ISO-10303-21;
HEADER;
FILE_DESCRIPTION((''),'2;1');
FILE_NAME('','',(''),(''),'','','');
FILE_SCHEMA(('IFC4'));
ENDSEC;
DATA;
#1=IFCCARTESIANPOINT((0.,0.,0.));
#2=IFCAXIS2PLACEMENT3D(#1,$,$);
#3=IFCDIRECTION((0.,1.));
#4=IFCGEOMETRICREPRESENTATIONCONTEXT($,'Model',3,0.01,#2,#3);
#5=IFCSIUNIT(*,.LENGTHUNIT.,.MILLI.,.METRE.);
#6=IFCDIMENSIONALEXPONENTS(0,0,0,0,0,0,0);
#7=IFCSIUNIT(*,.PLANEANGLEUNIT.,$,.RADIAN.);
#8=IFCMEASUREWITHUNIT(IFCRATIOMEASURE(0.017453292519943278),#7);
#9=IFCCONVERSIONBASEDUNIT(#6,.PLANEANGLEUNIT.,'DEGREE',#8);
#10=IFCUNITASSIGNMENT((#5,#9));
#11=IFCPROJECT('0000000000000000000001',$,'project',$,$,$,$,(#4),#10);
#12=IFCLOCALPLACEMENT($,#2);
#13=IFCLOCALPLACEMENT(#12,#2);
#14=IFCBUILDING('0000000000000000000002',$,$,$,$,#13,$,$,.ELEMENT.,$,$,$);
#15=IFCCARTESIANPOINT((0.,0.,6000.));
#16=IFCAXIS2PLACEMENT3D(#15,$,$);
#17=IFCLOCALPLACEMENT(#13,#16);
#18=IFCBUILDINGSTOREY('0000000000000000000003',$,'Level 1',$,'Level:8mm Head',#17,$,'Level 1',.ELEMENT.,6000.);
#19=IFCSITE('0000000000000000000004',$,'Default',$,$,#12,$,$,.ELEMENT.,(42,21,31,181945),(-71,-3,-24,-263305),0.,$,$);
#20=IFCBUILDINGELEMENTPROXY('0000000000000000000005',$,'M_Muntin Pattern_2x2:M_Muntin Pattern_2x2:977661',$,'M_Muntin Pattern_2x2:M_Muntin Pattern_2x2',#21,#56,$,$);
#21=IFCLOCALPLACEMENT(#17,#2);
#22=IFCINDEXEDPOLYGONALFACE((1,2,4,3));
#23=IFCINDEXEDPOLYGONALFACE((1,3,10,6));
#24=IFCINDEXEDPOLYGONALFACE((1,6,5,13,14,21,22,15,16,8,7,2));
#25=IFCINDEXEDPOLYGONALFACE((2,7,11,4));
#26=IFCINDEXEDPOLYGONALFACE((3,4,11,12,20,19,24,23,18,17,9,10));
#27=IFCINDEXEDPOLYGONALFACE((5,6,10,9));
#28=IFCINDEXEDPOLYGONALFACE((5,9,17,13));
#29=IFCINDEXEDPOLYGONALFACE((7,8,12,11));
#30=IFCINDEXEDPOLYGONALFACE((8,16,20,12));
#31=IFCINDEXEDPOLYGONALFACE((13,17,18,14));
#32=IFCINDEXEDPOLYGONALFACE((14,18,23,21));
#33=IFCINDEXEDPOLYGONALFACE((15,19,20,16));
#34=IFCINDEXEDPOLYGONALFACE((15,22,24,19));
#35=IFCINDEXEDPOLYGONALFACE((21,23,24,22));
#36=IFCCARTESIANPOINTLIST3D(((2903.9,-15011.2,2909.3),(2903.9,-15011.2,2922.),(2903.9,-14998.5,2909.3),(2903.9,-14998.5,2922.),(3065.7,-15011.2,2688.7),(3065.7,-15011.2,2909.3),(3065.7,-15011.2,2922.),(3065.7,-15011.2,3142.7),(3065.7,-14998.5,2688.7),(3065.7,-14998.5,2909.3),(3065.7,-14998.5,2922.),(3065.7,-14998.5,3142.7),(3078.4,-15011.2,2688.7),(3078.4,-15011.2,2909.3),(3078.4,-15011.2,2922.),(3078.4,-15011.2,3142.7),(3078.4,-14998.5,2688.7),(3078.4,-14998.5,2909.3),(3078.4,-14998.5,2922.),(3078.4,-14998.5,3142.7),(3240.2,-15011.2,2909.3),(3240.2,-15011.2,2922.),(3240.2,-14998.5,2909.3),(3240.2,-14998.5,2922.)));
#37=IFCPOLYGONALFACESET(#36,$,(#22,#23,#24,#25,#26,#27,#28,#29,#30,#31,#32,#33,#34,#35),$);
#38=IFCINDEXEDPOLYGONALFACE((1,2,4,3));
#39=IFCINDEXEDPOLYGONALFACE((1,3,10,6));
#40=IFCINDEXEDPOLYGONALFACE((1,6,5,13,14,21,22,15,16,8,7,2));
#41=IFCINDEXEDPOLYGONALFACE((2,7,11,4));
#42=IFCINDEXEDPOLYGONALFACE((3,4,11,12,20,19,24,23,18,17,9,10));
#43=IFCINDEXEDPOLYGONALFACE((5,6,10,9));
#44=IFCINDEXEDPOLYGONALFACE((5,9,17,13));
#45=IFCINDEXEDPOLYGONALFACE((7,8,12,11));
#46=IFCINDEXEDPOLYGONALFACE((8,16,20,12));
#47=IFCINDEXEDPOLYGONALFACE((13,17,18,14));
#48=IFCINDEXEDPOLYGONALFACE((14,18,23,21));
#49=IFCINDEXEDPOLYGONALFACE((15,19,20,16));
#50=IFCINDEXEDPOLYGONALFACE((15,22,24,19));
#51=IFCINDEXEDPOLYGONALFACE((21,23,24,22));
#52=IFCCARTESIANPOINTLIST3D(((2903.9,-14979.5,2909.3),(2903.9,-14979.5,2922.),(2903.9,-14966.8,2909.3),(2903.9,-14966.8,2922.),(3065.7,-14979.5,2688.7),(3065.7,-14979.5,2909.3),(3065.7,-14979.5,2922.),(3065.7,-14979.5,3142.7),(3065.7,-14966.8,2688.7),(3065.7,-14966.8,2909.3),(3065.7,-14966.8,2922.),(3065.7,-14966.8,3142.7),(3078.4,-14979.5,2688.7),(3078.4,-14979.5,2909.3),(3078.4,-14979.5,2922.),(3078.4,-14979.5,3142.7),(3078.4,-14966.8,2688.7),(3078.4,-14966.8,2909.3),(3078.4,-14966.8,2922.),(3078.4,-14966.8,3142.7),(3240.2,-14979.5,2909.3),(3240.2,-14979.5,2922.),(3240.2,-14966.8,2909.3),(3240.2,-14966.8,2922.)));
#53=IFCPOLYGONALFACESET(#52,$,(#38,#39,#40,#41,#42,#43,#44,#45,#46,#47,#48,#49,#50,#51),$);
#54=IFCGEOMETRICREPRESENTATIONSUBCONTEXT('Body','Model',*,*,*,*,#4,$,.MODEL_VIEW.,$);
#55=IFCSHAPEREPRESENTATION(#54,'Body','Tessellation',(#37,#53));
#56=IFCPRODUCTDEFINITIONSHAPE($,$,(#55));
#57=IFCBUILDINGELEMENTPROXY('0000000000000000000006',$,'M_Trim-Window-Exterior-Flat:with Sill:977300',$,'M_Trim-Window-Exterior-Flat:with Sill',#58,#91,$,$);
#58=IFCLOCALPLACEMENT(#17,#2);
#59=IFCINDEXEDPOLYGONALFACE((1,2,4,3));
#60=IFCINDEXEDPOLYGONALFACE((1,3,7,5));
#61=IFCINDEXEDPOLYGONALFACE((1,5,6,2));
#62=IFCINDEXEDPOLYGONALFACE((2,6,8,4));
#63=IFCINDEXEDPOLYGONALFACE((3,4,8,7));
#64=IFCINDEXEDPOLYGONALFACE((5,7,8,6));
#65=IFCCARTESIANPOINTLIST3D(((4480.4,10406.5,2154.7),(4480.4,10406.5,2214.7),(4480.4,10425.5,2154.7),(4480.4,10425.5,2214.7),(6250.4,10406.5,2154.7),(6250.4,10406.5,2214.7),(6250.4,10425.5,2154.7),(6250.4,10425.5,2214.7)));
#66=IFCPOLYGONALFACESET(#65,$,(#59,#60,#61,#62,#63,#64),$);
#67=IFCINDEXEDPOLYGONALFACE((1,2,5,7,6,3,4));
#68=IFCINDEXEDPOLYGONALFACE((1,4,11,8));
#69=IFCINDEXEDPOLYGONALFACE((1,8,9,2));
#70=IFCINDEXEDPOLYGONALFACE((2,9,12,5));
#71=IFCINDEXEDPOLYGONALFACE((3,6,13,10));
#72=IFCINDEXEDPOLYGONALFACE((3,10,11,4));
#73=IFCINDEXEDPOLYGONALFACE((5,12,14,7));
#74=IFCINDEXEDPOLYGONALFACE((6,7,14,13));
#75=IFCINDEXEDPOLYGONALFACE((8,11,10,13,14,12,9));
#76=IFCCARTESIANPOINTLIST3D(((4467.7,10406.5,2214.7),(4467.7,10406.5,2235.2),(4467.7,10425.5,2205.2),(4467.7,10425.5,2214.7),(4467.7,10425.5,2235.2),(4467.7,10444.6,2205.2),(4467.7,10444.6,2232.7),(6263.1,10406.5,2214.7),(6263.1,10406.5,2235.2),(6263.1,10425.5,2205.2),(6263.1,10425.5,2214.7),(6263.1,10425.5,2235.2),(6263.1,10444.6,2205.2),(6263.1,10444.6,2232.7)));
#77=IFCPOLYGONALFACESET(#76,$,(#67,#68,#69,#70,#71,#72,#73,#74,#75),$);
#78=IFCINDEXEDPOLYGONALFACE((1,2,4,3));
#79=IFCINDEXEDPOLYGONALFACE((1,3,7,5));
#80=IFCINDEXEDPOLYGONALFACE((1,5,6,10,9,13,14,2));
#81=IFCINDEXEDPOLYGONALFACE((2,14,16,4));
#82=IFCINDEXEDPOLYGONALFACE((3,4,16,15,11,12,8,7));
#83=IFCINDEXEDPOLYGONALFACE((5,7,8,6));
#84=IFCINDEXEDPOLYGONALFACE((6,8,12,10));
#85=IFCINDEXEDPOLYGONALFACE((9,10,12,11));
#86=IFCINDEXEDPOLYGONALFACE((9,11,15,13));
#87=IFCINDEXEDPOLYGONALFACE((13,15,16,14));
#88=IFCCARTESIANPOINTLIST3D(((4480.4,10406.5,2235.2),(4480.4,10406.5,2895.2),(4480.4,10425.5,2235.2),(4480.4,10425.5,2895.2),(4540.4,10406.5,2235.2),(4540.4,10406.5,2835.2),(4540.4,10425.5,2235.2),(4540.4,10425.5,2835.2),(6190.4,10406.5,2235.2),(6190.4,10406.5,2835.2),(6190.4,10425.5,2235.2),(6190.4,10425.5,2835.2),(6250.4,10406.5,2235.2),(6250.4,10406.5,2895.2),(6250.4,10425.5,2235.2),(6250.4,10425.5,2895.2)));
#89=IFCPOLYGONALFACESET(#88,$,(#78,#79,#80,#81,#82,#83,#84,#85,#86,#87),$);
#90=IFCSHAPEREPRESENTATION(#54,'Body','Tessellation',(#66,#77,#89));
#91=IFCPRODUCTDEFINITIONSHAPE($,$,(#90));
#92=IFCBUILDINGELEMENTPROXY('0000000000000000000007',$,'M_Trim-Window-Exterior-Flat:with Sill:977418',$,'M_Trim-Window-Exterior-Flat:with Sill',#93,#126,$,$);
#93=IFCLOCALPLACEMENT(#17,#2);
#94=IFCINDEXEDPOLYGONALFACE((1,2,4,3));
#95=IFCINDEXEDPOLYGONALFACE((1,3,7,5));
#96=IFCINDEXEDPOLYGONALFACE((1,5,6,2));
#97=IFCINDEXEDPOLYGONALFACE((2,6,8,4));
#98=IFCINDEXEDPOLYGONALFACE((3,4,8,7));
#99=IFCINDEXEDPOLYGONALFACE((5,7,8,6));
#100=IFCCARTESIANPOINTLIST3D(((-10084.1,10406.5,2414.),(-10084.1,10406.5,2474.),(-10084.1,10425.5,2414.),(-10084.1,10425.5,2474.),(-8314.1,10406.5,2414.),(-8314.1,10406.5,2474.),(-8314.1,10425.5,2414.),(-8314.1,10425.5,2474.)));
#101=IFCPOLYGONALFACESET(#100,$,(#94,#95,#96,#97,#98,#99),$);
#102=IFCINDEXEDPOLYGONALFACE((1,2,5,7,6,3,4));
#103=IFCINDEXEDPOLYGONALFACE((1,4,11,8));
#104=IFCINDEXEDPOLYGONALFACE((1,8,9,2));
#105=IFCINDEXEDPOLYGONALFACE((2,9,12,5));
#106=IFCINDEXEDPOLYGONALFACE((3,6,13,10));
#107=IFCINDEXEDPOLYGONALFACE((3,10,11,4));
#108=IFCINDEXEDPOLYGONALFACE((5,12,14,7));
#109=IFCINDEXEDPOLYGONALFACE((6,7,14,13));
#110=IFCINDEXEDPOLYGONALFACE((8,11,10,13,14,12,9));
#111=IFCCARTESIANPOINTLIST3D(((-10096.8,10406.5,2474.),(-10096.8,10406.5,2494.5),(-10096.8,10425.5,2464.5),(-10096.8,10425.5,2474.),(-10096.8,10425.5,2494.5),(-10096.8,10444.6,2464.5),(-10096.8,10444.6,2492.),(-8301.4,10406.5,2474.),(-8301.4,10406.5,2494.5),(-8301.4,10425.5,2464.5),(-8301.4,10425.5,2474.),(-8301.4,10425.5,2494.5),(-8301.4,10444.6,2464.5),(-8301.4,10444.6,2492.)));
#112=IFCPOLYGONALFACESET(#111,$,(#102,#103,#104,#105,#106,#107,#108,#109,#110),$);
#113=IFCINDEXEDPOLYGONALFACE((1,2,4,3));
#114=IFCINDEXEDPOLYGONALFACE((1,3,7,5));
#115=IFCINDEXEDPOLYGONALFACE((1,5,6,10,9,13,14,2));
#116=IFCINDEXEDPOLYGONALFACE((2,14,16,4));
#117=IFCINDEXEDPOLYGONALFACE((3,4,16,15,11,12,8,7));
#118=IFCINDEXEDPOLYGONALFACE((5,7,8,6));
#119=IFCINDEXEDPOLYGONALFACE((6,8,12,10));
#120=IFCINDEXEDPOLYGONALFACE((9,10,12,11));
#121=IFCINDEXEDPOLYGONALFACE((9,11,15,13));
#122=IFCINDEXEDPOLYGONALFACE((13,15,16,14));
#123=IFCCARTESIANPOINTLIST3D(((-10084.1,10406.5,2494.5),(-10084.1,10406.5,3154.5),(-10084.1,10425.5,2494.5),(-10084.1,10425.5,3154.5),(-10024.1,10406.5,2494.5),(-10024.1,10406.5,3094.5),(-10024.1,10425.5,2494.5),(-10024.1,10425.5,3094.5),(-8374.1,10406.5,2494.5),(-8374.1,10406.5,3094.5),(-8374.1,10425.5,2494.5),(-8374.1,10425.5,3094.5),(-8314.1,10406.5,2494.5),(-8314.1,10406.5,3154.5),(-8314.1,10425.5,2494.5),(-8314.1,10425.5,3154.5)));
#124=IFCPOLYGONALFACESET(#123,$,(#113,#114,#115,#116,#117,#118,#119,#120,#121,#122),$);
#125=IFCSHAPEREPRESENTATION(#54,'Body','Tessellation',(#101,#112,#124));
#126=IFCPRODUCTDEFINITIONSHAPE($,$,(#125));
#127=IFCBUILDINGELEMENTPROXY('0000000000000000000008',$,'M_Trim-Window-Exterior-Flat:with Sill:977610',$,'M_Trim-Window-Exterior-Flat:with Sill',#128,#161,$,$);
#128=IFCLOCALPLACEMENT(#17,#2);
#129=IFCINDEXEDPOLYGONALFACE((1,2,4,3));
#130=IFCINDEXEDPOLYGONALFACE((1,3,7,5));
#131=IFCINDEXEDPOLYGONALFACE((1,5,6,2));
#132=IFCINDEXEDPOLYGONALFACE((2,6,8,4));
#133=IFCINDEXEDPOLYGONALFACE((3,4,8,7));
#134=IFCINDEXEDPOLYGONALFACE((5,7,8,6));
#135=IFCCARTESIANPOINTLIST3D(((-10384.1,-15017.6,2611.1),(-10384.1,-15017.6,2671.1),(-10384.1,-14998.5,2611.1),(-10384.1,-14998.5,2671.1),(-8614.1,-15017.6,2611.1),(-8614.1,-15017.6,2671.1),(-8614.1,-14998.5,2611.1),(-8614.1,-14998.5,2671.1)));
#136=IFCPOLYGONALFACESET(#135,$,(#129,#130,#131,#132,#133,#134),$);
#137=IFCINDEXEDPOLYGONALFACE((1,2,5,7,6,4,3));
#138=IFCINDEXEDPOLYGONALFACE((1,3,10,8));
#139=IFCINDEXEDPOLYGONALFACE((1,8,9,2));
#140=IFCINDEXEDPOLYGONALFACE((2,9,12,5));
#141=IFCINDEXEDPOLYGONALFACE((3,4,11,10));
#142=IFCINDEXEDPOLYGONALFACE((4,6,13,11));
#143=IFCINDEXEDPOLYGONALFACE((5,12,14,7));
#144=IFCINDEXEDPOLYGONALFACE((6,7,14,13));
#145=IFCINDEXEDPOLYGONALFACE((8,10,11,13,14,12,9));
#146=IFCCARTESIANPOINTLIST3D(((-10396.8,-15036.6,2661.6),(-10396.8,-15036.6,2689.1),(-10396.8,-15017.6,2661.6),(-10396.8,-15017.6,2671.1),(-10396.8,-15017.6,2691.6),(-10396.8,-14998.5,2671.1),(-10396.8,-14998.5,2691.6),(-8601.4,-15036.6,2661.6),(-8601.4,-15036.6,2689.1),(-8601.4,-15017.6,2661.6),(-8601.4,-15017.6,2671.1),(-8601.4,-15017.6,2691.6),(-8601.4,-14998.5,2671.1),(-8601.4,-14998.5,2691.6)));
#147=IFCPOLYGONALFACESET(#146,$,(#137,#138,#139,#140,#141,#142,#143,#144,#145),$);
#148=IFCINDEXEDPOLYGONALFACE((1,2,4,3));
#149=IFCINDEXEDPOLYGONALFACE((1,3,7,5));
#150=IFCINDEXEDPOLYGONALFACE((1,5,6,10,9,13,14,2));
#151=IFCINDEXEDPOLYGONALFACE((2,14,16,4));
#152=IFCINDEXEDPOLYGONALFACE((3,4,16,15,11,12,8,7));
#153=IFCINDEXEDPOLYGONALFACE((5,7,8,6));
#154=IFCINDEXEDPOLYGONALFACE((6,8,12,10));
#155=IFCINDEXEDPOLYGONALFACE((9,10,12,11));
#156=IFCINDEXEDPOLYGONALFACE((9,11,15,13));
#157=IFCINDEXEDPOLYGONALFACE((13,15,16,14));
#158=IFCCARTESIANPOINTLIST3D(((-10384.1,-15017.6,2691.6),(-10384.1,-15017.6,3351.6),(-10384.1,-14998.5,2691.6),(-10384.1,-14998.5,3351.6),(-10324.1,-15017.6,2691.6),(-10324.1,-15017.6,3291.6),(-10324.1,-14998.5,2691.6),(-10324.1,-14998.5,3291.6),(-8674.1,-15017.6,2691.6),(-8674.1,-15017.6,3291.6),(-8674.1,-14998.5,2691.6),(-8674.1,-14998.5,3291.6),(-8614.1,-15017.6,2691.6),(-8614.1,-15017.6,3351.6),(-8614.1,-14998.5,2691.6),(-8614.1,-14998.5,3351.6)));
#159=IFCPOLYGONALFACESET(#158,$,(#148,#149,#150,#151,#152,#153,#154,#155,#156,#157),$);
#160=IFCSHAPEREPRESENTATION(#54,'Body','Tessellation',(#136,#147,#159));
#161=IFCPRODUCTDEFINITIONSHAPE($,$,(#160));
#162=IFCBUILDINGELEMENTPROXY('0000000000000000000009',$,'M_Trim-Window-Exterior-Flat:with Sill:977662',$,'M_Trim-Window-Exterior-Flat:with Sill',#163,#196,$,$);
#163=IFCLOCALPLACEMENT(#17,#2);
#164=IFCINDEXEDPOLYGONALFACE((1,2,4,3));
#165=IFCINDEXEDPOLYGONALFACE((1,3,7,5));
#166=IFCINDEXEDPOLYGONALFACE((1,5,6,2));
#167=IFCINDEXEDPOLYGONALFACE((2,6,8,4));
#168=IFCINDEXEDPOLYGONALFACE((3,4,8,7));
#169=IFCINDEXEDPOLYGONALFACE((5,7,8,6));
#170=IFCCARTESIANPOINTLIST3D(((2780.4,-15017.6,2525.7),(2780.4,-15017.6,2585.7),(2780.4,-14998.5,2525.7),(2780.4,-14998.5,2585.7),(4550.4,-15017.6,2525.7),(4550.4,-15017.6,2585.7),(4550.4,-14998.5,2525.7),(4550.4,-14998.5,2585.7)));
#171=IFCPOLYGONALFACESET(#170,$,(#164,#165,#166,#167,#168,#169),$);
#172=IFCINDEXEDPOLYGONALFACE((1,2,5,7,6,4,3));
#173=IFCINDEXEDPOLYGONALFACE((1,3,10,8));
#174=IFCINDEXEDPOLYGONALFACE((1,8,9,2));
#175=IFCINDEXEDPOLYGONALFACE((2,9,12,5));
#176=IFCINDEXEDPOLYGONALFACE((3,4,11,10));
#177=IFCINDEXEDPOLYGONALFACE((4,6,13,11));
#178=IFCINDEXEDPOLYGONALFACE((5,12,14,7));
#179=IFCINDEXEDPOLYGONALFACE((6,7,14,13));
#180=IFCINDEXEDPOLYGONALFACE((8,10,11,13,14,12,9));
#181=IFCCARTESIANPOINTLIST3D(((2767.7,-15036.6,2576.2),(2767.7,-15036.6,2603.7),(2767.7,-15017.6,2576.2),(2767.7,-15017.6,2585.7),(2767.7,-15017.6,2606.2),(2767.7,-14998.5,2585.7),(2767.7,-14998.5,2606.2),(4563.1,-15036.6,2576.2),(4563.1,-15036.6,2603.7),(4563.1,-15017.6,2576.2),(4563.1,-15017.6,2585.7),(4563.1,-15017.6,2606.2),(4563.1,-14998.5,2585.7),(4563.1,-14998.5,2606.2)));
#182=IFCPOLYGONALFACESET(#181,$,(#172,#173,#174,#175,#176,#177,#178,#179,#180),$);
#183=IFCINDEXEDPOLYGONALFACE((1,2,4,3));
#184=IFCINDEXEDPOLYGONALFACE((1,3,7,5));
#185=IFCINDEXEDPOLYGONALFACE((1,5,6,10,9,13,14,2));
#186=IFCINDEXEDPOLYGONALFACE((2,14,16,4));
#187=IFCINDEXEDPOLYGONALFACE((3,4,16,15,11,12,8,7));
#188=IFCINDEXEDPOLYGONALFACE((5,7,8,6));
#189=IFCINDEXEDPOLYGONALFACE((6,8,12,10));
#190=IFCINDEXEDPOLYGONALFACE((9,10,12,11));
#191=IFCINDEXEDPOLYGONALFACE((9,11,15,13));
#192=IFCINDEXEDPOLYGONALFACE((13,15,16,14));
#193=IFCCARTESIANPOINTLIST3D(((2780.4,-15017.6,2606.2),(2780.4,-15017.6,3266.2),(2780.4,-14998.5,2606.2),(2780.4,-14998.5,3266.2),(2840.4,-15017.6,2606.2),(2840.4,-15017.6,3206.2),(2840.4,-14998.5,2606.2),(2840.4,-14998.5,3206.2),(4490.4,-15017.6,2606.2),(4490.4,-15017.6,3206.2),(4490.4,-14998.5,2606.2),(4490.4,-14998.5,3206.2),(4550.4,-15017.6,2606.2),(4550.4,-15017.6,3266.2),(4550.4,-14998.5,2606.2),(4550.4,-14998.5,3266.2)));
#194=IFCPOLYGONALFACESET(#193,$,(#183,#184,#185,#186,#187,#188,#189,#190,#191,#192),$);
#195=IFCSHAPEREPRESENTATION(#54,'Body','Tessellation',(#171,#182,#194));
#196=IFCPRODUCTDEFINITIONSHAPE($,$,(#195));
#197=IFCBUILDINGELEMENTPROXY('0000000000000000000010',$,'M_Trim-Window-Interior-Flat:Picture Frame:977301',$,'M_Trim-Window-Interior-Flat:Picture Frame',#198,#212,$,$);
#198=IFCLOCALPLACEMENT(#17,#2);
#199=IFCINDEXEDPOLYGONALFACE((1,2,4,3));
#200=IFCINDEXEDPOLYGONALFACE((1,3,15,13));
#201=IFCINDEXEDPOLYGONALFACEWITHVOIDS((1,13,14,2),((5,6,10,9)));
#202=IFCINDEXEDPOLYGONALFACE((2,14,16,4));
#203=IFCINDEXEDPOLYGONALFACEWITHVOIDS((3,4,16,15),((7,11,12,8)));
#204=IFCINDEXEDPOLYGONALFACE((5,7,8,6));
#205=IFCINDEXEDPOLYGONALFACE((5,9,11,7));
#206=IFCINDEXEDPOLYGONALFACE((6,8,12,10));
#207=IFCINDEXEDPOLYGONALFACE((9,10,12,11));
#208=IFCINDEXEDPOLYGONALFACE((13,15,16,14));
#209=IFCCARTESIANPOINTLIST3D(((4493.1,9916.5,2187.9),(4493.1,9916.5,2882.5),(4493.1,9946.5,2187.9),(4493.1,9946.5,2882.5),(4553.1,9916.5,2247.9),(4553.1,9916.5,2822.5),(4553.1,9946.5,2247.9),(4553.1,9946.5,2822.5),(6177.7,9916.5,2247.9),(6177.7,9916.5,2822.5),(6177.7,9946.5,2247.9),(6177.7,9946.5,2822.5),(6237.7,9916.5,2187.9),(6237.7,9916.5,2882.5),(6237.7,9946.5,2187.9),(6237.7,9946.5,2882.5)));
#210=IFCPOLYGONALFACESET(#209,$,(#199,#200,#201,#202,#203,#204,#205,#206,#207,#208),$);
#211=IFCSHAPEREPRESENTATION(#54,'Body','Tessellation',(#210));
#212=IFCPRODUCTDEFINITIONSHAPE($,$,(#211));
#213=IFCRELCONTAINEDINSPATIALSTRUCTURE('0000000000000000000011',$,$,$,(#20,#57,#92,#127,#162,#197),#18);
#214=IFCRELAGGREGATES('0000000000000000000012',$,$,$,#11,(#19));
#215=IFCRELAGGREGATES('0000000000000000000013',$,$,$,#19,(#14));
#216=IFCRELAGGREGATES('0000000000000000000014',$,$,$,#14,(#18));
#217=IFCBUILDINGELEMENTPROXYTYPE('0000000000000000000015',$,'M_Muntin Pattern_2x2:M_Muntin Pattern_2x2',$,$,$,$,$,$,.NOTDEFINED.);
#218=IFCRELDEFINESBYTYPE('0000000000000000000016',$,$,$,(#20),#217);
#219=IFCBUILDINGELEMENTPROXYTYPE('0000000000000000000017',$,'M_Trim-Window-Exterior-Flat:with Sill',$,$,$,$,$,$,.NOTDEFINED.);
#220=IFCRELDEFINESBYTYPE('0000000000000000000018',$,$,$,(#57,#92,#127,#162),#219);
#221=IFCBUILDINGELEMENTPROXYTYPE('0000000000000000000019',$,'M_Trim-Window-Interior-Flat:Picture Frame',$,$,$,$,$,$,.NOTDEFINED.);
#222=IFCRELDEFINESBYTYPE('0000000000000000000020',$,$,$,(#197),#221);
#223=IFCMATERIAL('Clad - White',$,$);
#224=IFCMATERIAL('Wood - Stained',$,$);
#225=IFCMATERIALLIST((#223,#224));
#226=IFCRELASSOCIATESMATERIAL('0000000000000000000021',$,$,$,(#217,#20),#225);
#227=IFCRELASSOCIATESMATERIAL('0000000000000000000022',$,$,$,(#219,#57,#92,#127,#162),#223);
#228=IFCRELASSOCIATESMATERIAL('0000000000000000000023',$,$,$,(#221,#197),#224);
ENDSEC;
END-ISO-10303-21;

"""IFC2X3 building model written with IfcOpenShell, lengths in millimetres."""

from ifc_helpers import new_model, entity, si_unit, converted_unit, direction, frame, frame_2d, origin, place, context, subcontext, project, spatial, polyline, rectangle, outline, extrude, source, transform, mapped, material, material_list, type_object, type_shapes, element, save


model = new_model("IFC2X3")

# Units and contexts
model_context = context("Model", 3, precision=0.01, world=origin(), true_north=direction((0.0, 1.0)))
body_context = subcontext(model_context, "Body", "Model", "MODEL_VIEW")
ifc_project = project(units=[si_unit("LENGTHUNIT", "METRE", prefix="MILLI"), converted_unit("PLANEANGLEUNIT", "DEGREE", entity("IfcRatioMeasure", 0.017453292519943278), si_unit("PLANEANGLEUNIT", "RADIAN"), dimensions=[0, 0, 0, 0, 0, 0, 0])], contexts=[model_context])

# Site, building, storey
site_placement = place(None, origin())
site = spatial("IfcSite", under=ifc_project, at=site_placement, Name="Default", CompositionType="ELEMENT", RefLatitude=(42, 21, 31, 181945), RefLongitude=(-71, -3, -24, -263305), RefElevation=0.0)
building_placement = place(site_placement, origin())
building = spatial("IfcBuilding", under=site, at=building_placement, CompositionType="ELEMENT")
storey_placement = place(building_placement, frame((0.0, 0.0, 6000.0)))
storey = spatial("IfcBuildingStorey", under=building, at=storey_placement, Name="Level 1", ObjectType="Level:8mm Head", LongName="Level 1", CompositionType="ELEMENT", Elevation=6000.0)

# Building element proxies
ifc_material_1 = material(Name="Clad - White")
ifc_material_2 = material(Name="Wood - Stained")
ifc_material_list_1 = material_list([ifc_material_1, ifc_material_2])
building_element_proxy_type_1 = type_object("IfcBuildingElementProxyType", Name="M_Muntin Pattern_2x2:M_Muntin Pattern_2x2", PredefinedType="NOTDEFINED", material=ifc_material_list_1)
shared_shape_1 = source(origin(), body_context, "Body", "SweptSolid", [
    extrude(outline(polyline([(6.4, -6.4), (227.0, -6.4), (227.0, 6.3), (6.4, 6.3), (6.4, 168.2), (-6.3, 168.2), (-6.3, 6.3), (-227.0, 6.3), (-227.0, -6.4), (-6.3, -6.4), (-6.3, -168.1), (6.4, -168.1), (6.4, -6.4)])), frame((0.0, 9.5, 227.0), z_axis=(0.0, 1.0, 0.0), x_axis=(0.0, 0.0, 1.0)), (0.0, 0.0, 1.0), 12.7),
    extrude(outline(polyline([(6.4, -6.4), (227.0, -6.4), (227.0, 6.3), (6.4, 6.3), (6.4, 168.2), (-6.3, 168.2), (-6.3, 6.3), (-227.0, 6.3), (-227.0, -6.4), (-6.3, -6.4), (-6.3, -168.1), (6.4, -168.1), (6.4, -6.4)])), frame((0.0, -22.2, 227.0), z_axis=(0.0, 1.0, 0.0), x_axis=(0.0, 0.0, 1.0)), (0.0, 0.0, 1.0), 12.7),
])
type_shapes(building_element_proxy_type_1, [shared_shape_1])
for number, where, z_axis, x_axis, name in (
    (1, (3072.1, -14989.0, 2688.7), (0.0, 0.0, 1.0), (-1.0, 0.0, 0.0), "M_Muntin Pattern_2x2:M_Muntin Pattern_2x2:977661"),
):
    element("IfcBuildingElementProxy", number, at=place(storey_placement, frame(where, z_axis=z_axis, x_axis=x_axis)), inside=storey, type_object=building_element_proxy_type_1, material=ifc_material_list_1, Name=name, ObjectType="M_Muntin Pattern_2x2:M_Muntin Pattern_2x2", context=body_context, shape_type="MappedRepresentation", body=[
        mapped(shared_shape_1, transform((0.0, 0.0, 0.0), scale=1.0)),
    ])
building_element_proxy_type_2 = type_object("IfcBuildingElementProxyType", Name="M_Trim-Window-Exterior-Flat:with Sill", PredefinedType="NOTDEFINED", material=ifc_material_1)
shared_shape_2 = source(origin(), body_context, "Body", "SweptSolid", [
    extrude(rectangle(XDim=1770.0, YDim=60.0, at=frame_2d((0.0, 0.0), x_axis=(1.0, 0.0))), frame((0.0, -650.4, 0.0), z_axis=(0.0, 0.0, 1.0), x_axis=(-1.0, 0.0, 0.0)), (0.0, 0.0, 1.0), 19.0),
    extrude(outline(polyline([(-19.0, -15.2), (0.0, -15.2), (0.0, -5.7), (19.0, -5.7), (19.0, 14.8), (0.0, 14.8), (-19.0, 12.3), (-19.0, -15.2)])), frame((-897.7, -614.8, 19.0), z_axis=(1.0, 0.0, 0.0), x_axis=(0.0, 0.0, -1.0)), (0.0, 0.0, 1.0), 1795.4),
    extrude(outline(polyline([(-345.0, -885.0), (315.0, -885.0), (315.0, -825.0), (-285.0, -825.0), (-285.0, 825.0), (315.0, 825.0), (315.0, 885.0), (-345.0, 885.0), (-345.0, -885.0)])), frame((0.0, -285.0, 0.0), z_axis=(0.0, 0.0, 1.0), x_axis=(0.0, -1.0, 0.0)), (0.0, 0.0, 1.0), 19.0),
])
type_shapes(building_element_proxy_type_2, [shared_shape_2])
for number, where, z_axis, x_axis, name in (
    (2, (5365.4, 10406.5, 2835.2), (0.0, 1.0, 0.0), (-1.0, 0.0, 0.0), "M_Trim-Window-Exterior-Flat:with Sill:977300"),
    (3, (-9199.1, 10406.5, 3094.5), (0.0, 1.0, 0.0), (-1.0, 0.0, 0.0), "M_Trim-Window-Exterior-Flat:with Sill:977418"),
    (4, (-9499.1, -14998.5, 3291.6), (0.0, -1.0, 0.0), (1.0, 0.0, 0.0), "M_Trim-Window-Exterior-Flat:with Sill:977610"),
    (5, (3665.4, -14998.5, 3206.2), (0.0, -1.0, 0.0), (1.0, 0.0, 0.0), "M_Trim-Window-Exterior-Flat:with Sill:977662"),
):
    element("IfcBuildingElementProxy", number, at=place(storey_placement, frame(where, z_axis=z_axis, x_axis=x_axis)), inside=storey, type_object=building_element_proxy_type_2, material=ifc_material_1, Name=name, ObjectType="M_Trim-Window-Exterior-Flat:with Sill", context=body_context, shape_type="MappedRepresentation", body=[
        mapped(shared_shape_2, transform((0.0, 0.0, 0.0), scale=1.0)),
    ])
building_element_proxy_type_3 = type_object("IfcBuildingElementProxyType", Name="M_Trim-Window-Interior-Flat:Picture Frame", PredefinedType="NOTDEFINED", material=ifc_material_2)
shared_shape_3 = source(origin(), body_context, "Body", "SweptSolid", [
    extrude(outline(polyline([(-872.3, -347.3), (872.3, -347.3), (872.3, 347.3), (-872.3, 347.3), (-872.3, -347.3)]), holes=[polyline([(-812.3, -287.3), (-812.3, 287.3), (812.3, 287.3), (812.3, -287.3), (-812.3, -287.3)])]), frame((0.0, -300.0, 0.0), z_axis=(0.0, 0.0, 1.0), x_axis=(-1.0, 0.0, 0.0)), (0.0, 0.0, 1.0), 30.0),
])
type_shapes(building_element_proxy_type_3, [shared_shape_3])
for number, where, z_axis, x_axis, name in (
    (6, (5365.4, 9946.5, 2835.2), (0.0, -1.0, 0.0), (1.0, 0.0, 0.0), "M_Trim-Window-Interior-Flat:Picture Frame:977301"),
):
    element("IfcBuildingElementProxy", number, at=place(storey_placement, frame(where, z_axis=z_axis, x_axis=x_axis)), inside=storey, type_object=building_element_proxy_type_3, material=ifc_material_2, Name=name, ObjectType="M_Trim-Window-Interior-Flat:Picture Frame", context=body_context, shape_type="MappedRepresentation", body=[
        mapped(shared_shape_3, transform((0.0, 0.0, 0.0), scale=1.0)),
    ])

save(model, "model.ifc")
